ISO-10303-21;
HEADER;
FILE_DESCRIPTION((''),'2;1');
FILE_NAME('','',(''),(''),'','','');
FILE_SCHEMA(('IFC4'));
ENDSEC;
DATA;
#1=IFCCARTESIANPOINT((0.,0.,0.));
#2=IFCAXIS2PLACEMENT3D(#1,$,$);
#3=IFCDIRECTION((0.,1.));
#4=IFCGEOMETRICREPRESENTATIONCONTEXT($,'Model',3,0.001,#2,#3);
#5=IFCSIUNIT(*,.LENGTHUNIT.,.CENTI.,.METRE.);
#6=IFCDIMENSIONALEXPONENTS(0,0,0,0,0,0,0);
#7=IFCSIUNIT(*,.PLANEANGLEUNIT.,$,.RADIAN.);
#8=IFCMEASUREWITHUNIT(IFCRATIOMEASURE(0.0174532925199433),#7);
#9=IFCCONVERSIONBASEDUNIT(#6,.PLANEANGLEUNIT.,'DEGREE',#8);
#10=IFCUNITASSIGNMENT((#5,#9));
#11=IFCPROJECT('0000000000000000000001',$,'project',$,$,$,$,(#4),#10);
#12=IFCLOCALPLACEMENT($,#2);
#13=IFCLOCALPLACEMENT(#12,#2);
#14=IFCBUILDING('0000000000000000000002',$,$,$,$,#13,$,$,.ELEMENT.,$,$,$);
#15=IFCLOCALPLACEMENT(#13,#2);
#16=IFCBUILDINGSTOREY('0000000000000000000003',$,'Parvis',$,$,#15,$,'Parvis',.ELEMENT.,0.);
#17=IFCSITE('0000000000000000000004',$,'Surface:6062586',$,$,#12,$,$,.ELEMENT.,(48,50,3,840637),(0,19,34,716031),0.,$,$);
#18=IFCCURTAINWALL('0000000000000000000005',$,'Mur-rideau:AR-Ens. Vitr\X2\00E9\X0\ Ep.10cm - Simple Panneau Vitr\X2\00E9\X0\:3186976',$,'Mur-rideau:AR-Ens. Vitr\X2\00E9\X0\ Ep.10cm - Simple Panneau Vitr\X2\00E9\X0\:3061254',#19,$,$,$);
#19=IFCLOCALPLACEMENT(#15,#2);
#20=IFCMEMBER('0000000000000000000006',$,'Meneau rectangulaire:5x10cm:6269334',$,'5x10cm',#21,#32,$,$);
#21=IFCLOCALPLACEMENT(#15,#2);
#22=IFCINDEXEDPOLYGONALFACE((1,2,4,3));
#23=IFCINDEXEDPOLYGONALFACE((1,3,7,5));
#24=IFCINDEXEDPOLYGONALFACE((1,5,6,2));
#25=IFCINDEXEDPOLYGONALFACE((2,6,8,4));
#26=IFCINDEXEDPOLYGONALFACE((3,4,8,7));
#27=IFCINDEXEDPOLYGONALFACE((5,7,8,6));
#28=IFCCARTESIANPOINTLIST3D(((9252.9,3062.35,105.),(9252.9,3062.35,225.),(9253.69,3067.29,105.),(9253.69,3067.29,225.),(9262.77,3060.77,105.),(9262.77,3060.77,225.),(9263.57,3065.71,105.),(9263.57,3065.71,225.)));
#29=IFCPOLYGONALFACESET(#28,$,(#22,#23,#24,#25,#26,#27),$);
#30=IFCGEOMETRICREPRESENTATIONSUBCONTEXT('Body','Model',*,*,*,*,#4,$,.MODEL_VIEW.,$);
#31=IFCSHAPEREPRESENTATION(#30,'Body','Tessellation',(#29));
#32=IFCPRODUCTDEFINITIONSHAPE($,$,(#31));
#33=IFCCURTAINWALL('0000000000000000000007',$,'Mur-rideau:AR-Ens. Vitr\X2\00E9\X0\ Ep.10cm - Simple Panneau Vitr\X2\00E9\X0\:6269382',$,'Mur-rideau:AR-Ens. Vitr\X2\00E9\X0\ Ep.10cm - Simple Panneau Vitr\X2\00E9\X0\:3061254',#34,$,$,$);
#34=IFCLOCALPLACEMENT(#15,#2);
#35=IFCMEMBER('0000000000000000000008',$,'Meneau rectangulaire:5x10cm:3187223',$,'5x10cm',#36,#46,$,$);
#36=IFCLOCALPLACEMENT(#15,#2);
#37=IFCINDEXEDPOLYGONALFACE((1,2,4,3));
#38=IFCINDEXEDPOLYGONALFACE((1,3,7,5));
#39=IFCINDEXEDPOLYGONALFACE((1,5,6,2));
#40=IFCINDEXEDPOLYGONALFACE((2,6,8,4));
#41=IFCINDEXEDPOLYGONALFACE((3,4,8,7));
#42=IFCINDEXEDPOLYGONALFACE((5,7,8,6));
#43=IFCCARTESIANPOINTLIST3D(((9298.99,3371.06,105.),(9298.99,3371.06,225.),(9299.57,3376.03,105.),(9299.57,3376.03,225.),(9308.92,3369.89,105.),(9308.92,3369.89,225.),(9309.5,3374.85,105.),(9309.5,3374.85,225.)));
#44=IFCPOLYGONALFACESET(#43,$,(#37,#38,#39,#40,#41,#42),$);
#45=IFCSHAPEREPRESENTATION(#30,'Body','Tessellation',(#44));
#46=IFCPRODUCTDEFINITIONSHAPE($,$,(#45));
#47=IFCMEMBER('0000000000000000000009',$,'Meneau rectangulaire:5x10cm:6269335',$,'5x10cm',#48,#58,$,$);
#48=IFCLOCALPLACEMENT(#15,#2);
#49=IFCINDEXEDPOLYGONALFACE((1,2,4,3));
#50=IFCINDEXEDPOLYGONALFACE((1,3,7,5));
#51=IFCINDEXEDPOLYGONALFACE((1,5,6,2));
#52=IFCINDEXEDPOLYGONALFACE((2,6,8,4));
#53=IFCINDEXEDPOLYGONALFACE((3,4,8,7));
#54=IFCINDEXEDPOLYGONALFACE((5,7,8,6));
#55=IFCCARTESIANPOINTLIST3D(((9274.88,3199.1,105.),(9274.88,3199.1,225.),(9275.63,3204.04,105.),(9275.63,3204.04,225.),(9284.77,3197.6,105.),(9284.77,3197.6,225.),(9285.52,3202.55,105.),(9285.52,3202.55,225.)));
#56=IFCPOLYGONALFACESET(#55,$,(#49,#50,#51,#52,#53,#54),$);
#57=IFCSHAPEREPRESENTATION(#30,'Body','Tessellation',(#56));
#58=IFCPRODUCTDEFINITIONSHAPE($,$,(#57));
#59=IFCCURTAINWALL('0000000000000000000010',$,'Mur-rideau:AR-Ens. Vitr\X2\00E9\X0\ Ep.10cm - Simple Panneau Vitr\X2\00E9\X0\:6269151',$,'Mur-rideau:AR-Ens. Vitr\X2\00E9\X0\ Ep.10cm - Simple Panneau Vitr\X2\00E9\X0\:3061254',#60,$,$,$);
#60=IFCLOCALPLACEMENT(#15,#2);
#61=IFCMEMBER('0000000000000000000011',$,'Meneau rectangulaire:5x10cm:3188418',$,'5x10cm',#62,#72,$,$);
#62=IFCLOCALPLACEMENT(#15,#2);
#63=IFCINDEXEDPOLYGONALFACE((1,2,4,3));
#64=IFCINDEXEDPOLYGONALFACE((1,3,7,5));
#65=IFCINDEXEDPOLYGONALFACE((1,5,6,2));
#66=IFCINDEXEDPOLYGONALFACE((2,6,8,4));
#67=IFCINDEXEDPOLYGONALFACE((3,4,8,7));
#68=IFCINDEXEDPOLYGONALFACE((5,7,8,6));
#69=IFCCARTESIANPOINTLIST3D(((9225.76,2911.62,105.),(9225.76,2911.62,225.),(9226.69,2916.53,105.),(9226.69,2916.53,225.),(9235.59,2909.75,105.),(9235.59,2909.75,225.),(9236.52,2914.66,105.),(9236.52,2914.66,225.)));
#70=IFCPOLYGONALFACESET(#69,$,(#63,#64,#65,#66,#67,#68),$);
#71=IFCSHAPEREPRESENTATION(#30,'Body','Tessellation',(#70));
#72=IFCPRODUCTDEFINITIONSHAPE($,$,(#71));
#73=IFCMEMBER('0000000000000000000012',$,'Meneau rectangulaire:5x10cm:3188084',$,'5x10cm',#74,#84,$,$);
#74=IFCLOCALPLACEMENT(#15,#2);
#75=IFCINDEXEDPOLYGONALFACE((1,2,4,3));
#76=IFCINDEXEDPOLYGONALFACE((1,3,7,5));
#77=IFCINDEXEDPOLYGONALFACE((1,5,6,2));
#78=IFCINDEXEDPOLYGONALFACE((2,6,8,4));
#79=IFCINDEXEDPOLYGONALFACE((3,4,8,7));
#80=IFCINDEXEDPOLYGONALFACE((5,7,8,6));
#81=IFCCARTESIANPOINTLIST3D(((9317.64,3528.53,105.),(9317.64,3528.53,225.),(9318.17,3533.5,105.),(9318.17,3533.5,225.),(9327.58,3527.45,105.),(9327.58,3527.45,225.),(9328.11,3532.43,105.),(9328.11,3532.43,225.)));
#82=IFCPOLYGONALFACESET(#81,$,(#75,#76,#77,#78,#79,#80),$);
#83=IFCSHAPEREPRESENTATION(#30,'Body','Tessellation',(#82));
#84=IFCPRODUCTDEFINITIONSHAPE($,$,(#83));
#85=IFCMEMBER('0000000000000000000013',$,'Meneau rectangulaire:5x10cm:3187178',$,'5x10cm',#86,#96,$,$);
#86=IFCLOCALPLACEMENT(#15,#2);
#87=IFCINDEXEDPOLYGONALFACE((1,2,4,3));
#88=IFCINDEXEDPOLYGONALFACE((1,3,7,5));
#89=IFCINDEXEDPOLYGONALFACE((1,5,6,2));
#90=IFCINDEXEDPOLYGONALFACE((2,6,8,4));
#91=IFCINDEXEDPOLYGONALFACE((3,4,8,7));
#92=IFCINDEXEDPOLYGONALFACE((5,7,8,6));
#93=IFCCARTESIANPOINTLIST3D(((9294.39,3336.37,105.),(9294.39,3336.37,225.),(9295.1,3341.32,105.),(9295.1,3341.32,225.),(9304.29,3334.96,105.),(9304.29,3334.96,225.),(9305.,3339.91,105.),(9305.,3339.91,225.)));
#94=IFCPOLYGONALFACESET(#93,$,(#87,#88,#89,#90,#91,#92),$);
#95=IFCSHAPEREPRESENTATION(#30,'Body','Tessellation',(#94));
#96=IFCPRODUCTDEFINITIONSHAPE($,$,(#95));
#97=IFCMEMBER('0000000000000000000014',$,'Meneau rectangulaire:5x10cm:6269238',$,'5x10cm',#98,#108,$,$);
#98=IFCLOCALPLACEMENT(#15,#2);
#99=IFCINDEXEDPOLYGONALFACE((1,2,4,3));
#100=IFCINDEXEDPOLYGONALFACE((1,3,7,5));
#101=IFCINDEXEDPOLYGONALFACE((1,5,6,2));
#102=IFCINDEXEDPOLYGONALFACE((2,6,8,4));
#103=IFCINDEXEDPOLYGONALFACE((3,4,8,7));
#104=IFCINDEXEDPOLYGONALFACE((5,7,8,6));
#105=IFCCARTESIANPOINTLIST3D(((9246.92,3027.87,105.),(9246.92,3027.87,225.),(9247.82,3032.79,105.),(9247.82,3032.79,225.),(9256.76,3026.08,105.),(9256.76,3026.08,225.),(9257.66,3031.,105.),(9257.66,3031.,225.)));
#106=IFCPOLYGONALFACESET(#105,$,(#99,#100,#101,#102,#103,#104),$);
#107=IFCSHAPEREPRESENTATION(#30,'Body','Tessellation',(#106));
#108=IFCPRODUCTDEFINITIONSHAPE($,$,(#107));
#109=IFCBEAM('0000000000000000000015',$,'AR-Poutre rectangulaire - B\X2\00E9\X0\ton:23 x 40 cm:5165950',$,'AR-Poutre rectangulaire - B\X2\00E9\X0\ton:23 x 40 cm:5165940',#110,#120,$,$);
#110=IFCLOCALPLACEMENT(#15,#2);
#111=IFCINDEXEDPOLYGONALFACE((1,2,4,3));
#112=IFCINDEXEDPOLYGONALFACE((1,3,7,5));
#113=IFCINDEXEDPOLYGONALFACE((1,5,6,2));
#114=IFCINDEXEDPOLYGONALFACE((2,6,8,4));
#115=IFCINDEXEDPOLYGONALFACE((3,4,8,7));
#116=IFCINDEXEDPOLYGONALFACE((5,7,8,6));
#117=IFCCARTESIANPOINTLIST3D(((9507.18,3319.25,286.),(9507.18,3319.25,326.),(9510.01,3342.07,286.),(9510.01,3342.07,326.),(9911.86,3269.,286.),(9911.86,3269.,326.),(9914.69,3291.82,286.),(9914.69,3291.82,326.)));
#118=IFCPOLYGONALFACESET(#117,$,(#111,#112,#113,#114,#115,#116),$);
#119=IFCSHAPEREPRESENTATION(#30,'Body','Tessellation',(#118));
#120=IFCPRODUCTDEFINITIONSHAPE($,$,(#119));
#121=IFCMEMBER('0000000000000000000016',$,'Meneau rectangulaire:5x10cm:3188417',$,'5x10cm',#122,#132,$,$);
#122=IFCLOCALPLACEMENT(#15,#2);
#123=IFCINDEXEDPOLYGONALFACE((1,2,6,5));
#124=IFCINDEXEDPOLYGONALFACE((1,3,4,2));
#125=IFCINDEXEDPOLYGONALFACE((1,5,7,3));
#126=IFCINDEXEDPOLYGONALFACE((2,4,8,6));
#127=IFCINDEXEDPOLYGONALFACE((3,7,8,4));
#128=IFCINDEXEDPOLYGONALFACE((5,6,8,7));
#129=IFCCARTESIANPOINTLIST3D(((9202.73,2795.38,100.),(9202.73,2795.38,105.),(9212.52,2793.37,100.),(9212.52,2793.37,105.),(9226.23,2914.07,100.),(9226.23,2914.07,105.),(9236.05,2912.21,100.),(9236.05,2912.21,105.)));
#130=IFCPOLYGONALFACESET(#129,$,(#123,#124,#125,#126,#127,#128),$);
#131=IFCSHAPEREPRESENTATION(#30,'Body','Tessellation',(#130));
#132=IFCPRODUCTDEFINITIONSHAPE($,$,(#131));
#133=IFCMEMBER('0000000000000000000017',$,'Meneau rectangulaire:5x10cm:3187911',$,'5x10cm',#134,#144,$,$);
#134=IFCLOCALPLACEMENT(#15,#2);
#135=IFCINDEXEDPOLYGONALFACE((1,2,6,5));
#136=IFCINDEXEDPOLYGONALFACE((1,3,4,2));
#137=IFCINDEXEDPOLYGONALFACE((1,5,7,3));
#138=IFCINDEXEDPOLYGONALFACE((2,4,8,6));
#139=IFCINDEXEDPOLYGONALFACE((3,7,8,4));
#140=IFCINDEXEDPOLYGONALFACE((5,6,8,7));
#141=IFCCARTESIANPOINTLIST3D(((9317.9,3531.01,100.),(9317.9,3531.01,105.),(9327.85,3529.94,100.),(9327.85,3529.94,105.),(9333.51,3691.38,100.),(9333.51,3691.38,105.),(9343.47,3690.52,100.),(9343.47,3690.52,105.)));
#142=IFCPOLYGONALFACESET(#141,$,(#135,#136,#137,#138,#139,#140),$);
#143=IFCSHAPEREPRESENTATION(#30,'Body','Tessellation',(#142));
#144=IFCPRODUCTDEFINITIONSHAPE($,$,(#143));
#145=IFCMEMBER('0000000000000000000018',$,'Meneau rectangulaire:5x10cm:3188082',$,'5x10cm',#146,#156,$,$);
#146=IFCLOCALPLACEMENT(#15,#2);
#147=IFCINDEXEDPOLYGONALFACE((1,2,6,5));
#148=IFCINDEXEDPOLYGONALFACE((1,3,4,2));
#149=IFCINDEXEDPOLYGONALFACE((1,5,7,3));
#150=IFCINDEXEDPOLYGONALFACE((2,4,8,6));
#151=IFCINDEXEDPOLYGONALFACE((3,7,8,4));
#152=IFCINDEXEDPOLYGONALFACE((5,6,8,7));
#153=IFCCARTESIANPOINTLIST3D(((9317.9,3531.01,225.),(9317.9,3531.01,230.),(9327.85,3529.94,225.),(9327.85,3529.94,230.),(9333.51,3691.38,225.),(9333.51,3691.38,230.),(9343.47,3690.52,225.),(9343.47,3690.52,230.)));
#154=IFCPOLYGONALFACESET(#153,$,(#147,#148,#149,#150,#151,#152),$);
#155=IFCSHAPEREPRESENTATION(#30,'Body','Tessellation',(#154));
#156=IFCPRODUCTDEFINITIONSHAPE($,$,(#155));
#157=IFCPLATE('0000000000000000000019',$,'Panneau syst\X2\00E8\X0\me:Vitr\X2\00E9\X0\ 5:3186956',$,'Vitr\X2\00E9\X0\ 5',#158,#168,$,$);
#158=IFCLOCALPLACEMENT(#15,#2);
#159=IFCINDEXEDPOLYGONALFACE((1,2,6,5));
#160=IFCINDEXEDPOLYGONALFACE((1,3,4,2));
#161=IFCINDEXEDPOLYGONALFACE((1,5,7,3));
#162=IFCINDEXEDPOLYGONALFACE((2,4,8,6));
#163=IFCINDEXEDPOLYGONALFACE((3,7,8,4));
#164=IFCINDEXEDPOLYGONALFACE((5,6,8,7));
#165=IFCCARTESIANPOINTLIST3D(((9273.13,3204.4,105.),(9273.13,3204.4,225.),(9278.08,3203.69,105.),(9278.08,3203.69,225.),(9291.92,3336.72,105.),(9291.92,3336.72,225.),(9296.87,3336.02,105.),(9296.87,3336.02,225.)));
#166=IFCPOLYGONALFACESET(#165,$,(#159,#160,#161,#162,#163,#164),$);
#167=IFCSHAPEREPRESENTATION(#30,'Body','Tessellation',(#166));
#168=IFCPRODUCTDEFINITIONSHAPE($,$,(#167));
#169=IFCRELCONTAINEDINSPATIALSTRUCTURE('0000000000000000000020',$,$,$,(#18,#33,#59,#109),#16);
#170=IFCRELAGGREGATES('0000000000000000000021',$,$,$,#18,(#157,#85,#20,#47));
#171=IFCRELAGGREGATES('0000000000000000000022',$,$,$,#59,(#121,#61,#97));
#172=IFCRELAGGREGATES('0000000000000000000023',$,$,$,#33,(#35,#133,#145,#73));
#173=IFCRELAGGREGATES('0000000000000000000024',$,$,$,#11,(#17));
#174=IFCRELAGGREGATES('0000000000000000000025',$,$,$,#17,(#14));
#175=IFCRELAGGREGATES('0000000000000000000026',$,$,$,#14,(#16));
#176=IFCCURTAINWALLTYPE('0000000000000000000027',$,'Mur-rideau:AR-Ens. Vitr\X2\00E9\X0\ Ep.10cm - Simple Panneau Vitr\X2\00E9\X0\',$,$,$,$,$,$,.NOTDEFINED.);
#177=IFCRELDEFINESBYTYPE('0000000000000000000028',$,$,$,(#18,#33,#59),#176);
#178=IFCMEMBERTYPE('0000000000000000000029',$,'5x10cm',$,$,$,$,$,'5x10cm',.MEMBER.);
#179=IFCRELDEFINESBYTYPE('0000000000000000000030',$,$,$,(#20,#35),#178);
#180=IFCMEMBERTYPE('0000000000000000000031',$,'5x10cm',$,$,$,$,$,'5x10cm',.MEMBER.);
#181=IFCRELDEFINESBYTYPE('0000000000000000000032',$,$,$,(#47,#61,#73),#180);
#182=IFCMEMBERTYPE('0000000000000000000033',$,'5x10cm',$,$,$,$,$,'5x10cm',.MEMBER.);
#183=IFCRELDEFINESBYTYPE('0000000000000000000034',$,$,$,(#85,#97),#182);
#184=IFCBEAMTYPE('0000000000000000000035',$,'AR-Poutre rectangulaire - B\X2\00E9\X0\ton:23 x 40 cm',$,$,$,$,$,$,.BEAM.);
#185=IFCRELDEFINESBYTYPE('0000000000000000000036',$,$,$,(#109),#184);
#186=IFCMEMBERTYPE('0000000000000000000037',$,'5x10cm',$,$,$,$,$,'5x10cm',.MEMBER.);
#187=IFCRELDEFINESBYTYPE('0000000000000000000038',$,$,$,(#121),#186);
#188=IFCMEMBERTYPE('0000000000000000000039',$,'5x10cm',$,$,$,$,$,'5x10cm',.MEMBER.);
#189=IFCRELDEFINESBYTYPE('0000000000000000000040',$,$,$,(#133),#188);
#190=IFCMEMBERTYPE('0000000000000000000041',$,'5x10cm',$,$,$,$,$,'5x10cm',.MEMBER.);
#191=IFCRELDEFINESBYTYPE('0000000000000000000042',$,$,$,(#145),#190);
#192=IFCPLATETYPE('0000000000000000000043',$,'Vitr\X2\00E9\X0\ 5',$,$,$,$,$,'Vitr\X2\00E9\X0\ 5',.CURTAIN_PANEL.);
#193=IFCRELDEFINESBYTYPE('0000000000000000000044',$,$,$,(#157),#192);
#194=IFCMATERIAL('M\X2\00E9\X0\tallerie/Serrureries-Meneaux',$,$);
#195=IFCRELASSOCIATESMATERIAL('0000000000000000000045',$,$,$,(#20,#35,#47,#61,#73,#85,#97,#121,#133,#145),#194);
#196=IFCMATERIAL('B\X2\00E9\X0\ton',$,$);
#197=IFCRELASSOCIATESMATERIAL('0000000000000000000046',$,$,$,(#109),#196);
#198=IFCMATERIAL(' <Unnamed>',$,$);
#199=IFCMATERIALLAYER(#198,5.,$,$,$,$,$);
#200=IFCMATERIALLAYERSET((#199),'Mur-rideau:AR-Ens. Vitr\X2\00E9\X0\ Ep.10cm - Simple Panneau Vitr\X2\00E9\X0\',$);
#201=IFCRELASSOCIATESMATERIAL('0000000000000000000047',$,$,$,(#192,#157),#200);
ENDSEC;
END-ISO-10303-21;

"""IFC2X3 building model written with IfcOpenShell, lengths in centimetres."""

from ifc_helpers import new_model, entity, si_unit, converted_unit, direction, frame, frame_2d, origin, origin_2d_with_axis, place, context, subcontext, project, spatial, rectangle, extrude, clip, halfspace, source, transform, mapped, material, layer, layer_set, layer_usage, type_object, type_shapes, element, aggregate, save


model = new_model("IFC2X3")

# Units and contexts
model_context = context("Model", 3, precision=0.001, world=origin(), true_north=direction((0.0, 1.0)))
body_context = subcontext(model_context, "Body", "Model", "MODEL_VIEW")
ifc_project = project(units=[si_unit("LENGTHUNIT", "METRE", prefix="CENTI"), converted_unit("PLANEANGLEUNIT", "DEGREE", entity("IfcRatioMeasure", 0.0174532925199433), si_unit("PLANEANGLEUNIT", "RADIAN"), dimensions=[0, 0, 0, 0, 0, 0, 0])], contexts=[model_context])

# Site, building, storey
site_placement = place(None, origin())
site = spatial("IfcSite", under=ifc_project, at=site_placement, Name="Surface:6062586", CompositionType="ELEMENT", RefLatitude=(48, 50, 3, 840637), RefLongitude=(0, 19, 34, 716031), RefElevation=0.0)
building_placement = place(site_placement, origin())
building = spatial("IfcBuilding", under=site, at=building_placement, CompositionType="ELEMENT")
storey_placement = place(building_placement, frame((0.0, 0.0, 0.0)))
storey = spatial("IfcBuildingStorey", under=building, at=storey_placement, Name="Parvis", LongName="Parvis", CompositionType="ELEMENT", Elevation=0.0)

# Shared definitions
ifc_material_1 = material(Name="Béton")

# Curtain walls, members
curtain_wall_type = type_object("IfcCurtainWallType", Name="Mur-rideau:AR-Ens. Vitré Ep.10cm - Simple Panneau Vitré", PredefinedType="NOTDEFINED")
curtain_wall_1_placement = place(storey_placement, frame((0.0, 0.0, 0.0)))
curtain_wall_1 = element("IfcCurtainWall", 1, at=curtain_wall_1_placement, inside=storey, type_object=curtain_wall_type, Name="Mur-rideau:AR-Ens. Vitré Ep.10cm - Simple Panneau Vitré:3186976", ObjectType="Mur-rideau:AR-Ens. Vitré Ep.10cm - Simple Panneau Vitré:3061254")
ifc_material_2 = material(Name="Métallerie/Serrureries-Meneaux")
member_type_1 = type_object("IfcMemberType", Name="5x10cm", ElementType="5x10cm", PredefinedType="MEMBER")
shared_shape_1 = source(origin(), body_context, "Body", "SweptSolid", [
    extrude(rectangle(XDim=10.0, YDim=5.0, at=origin_2d_with_axis()), frame((-2.5, -5.0, -120.0), z_axis=(0.0, 0.0, 1.0), x_axis=(0.0, -1.0, 0.0)), (0.0, 0.0, 1.0), 120.0),
])
type_shapes(member_type_1, [shared_shape_1])
member_1_placement = place(storey_placement, frame((9252.9, 3062.35, 105.0), z_axis=(0.0, 0.0, -1.0), x_axis=(-0.158533, -0.987354, 0.0)))
member_1 = element("IfcMember", 2, at=member_1_placement, type_object=member_type_1, material=ifc_material_2, Name="Meneau rectangulaire:5x10cm:6269334", ObjectType="5x10cm", context=body_context, shape_type="MappedRepresentation", body=[
    mapped(shared_shape_1, transform((0.0, 0.0, 0.0), scale=1.0)),
])
curtain_wall_2_placement = place(storey_placement, frame((0.0, 0.0, 0.0)))
curtain_wall_2 = element("IfcCurtainWall", 3, at=curtain_wall_2_placement, inside=storey, type_object=curtain_wall_type, Name="Mur-rideau:AR-Ens. Vitré Ep.10cm - Simple Panneau Vitré:6269382", ObjectType="Mur-rideau:AR-Ens. Vitré Ep.10cm - Simple Panneau Vitré:3061254")
member_2_placement = place(storey_placement, frame((9298.99, 3371.06, 105.0), z_axis=(0.0, 0.0, -1.0), x_axis=(-0.117457, -0.993078, 0.0)))
member_2 = element("IfcMember", 4, at=member_2_placement, type_object=member_type_1, material=ifc_material_2, Name="Meneau rectangulaire:5x10cm:3187223", ObjectType="5x10cm", context=body_context, shape_type="MappedRepresentation", body=[
    mapped(shared_shape_1, transform((0.0, 0.0, 0.0), scale=1.0)),
])

# Member
member_type_2 = type_object("IfcMemberType", Name="5x10cm", ElementType="5x10cm", PredefinedType="MEMBER")
shared_shape_2 = source(origin(), body_context, "Body", "SweptSolid", [
    extrude(rectangle(XDim=10.0, YDim=5.0, at=origin_2d_with_axis()), frame((0.0, -5.0, -120.0), z_axis=(0.0, 0.0, 1.0), x_axis=(0.0, -1.0, 0.0)), (0.0, 0.0, 1.0), 120.0),
])
type_shapes(member_type_2, [shared_shape_2])
member_3_placement = place(storey_placement, frame((9275.25, 3201.57, 105.0), z_axis=(0.0, 0.0, -1.0), x_axis=(-0.149566, -0.988752, 0.0)))
member_3 = element("IfcMember", 5, at=member_3_placement, type_object=member_type_2, material=ifc_material_2, Name="Meneau rectangulaire:5x10cm:6269335", ObjectType="5x10cm", context=body_context, shape_type="MappedRepresentation", body=[
    mapped(shared_shape_2, transform((0.0, 0.0, 0.0), scale=1.0)),
])

# Curtain wall, member
curtain_wall_3_placement = place(storey_placement, frame((0.0, 0.0, 0.0)))
curtain_wall_3 = element("IfcCurtainWall", 6, at=curtain_wall_3_placement, inside=storey, type_object=curtain_wall_type, Name="Mur-rideau:AR-Ens. Vitré Ep.10cm - Simple Panneau Vitré:6269151", ObjectType="Mur-rideau:AR-Ens. Vitré Ep.10cm - Simple Panneau Vitré:3061254")
member_4_placement = place(storey_placement, frame((9226.23, 2914.07, 105.0), z_axis=(0.0, 0.0, -1.0), x_axis=(-0.186576, -0.982441, 0.0)))
member_4 = element("IfcMember", 7, at=member_4_placement, type_object=member_type_2, material=ifc_material_2, Name="Meneau rectangulaire:5x10cm:3188418", ObjectType="5x10cm", context=body_context, shape_type="MappedRepresentation", body=[
    mapped(shared_shape_2, transform((0.0, 0.0, 0.0), scale=1.0)),
])

# Members
member_5_placement = place(storey_placement, frame((9317.9, 3531.01, 105.0), z_axis=(0.0, 0.0, -1.0), x_axis=(-0.107155, -0.994242, 0.0)))
member_5 = element("IfcMember", 8, at=member_5_placement, type_object=member_type_2, material=ifc_material_2, Name="Meneau rectangulaire:5x10cm:3188084", ObjectType="5x10cm", context=body_context, shape_type="MappedRepresentation", body=[
    mapped(shared_shape_2, transform((0.0, 0.0, 0.0), scale=1.0)),
])
member_type_3 = type_object("IfcMemberType", Name="5x10cm", ElementType="5x10cm", PredefinedType="MEMBER")
shared_shape_3 = source(origin(), body_context, "Body", "SweptSolid", [
    extrude(rectangle(XDim=10.0, YDim=5.0, at=origin_2d_with_axis()), frame((-2.5, -5.0, -120.0), z_axis=(0.0, 0.0, 1.0), x_axis=(0.0, -1.0, 0.0)), (0.0, 0.0, 1.0), 120.0),
])
type_shapes(member_type_3, [shared_shape_3])
member_6_placement = place(storey_placement, frame((9295.1, 3341.32, 225.0), z_axis=(0.0, 0.0, 1.0), x_axis=(0.140576, 0.99007, 0.0)))
member_6 = element("IfcMember", 9, at=member_6_placement, type_object=member_type_3, material=ifc_material_2, Name="Meneau rectangulaire:5x10cm:3187178", ObjectType="5x10cm", context=body_context, shape_type="MappedRepresentation", body=[
    mapped(shared_shape_3, transform((0.0, 0.0, 0.0), scale=1.0)),
])
member_7_placement = place(storey_placement, frame((9247.82, 3032.79, 225.0), z_axis=(0.0, 0.0, 1.0), x_axis=(0.17894, 0.98386, 0.0)))
member_7 = element("IfcMember", 10, at=member_7_placement, type_object=member_type_3, material=ifc_material_2, Name="Meneau rectangulaire:5x10cm:6269238", ObjectType="5x10cm", context=body_context, shape_type="MappedRepresentation", body=[
    mapped(shared_shape_3, transform((0.0, 0.0, 0.0), scale=1.0)),
])

# Beam
beam_type_1 = type_object("IfcBeamType", Name="AR-Poutre rectangulaire - Béton:23 x 40 cm", PredefinedType="BEAM")
beam_1_placement = place(storey_placement, frame((9508.59, 3330.66, 326.0), z_axis=(0.0, 0.0, 1.0), x_axis=(0.992379, -0.123227, 0.0)))
element("IfcBeam", 11, at=beam_1_placement, inside=storey, type_object=beam_type_1, material=ifc_material_1, Name="AR-Poutre rectangulaire - Béton:23 x 40 cm:5165950", ObjectType="AR-Poutre rectangulaire - Béton:23 x 40 cm:5165940", context=body_context, shape_type="SweptSolid", body=[
    extrude(rectangle(XDim=40.0, YDim=23.0, at=frame_2d((0.0, 0.0), x_axis=(1.0, 0.0))), frame((0.0, 0.0, -20.0), z_axis=(1.0, 0.0, 0.0), x_axis=(0.0, 0.0, -1.0)), (0.0, 0.0, 1.0), 407.79),
])

# Members
member_type_4 = type_object("IfcMemberType", Name="5x10cm", ElementType="5x10cm", PredefinedType="MEMBER")
shared_shape_4 = source(origin(), body_context, "Body", "Clipping", [
    clip(clip(extrude(rectangle(XDim=10.0, YDim=5.0, at=origin_2d_with_axis()), frame((-2.5, -5.0, -121.07), z_axis=(0.0, 0.0, 1.0), x_axis=(0.0, -1.0, 0.0)), (0.0, 0.0, 1.0), 121.15), halfspace(frame((-30.48, 0.0, -120.99), z_axis=(0.0, 0.007777, -0.99997), x_axis=(1.0, 0.0, 0.0)), False)), halfspace(frame((-30.48, 0.0, 0.0), z_axis=(0.0, 0.007777, 0.99997), x_axis=(1.0, 0.0, 0.0)), False)),
])
type_shapes(member_type_4, [shared_shape_4])
member_8_placement = place(storey_placement, frame((9226.23, 2914.07, 100.0), z_axis=(0.194221, 0.980958, 0.0), x_axis=(0.0, 0.0, -1.0)))
member_8 = element("IfcMember", 12, at=member_8_placement, type_object=member_type_4, material=ifc_material_2, Name="Meneau rectangulaire:5x10cm:3188417", ObjectType="5x10cm", context=body_context, shape_type="MappedRepresentation", body=[
    mapped(shared_shape_4, transform((0.0, 0.0, 0.0), scale=1.0)),
])
member_type_5 = type_object("IfcMemberType", Name="5x10cm", ElementType="5x10cm", PredefinedType="MEMBER")
shared_shape_5 = source(origin(), body_context, "Body", "Clipping", [
    clip(clip(extrude(rectangle(XDim=10.0, YDim=5.0, at=origin_2d_with_axis()), frame((-2.5, -5.0, -161.23), z_axis=(0.0, 0.0, 1.0), x_axis=(0.0, -1.0, 0.0)), (0.0, 0.0, 1.0), 161.34), halfspace(frame((-30.48, 0.0, -161.13), z_axis=(0.0, 0.010369, -0.999946), x_axis=(1.0, 0.0, 0.0)), False)), halfspace(frame((-30.48, 0.0, 0.0), z_axis=(0.0, 0.010369, 0.999946), x_axis=(1.0, 0.0, 0.0)), False)),
])
type_shapes(member_type_5, [shared_shape_5])
member_9_placement = place(storey_placement, frame((9333.51, 3691.38, 100.0), z_axis=(0.096838, 0.9953, 0.0), x_axis=(0.0, 0.0, -1.0)))
member_9 = element("IfcMember", 13, at=member_9_placement, type_object=member_type_5, material=ifc_material_2, Name="Meneau rectangulaire:5x10cm:3187911", ObjectType="5x10cm", context=body_context, shape_type="MappedRepresentation", body=[
    mapped(shared_shape_5, transform((0.0, 0.0, 0.0), scale=1.0)),
])
member_type_6 = type_object("IfcMemberType", Name="5x10cm", ElementType="5x10cm", PredefinedType="MEMBER")
shared_shape_6 = source(origin(), body_context, "Body", "Clipping", [
    clip(clip(extrude(rectangle(XDim=10.0, YDim=5.0, at=origin_2d_with_axis()), frame((-2.5, -5.0, -161.23), z_axis=(0.0, 0.0, 1.0), x_axis=(0.0, -1.0, 0.0)), (0.0, 0.0, 1.0), 161.34), halfspace(frame((-30.48, 0.0, -161.13), z_axis=(0.0, 0.010369, -0.999946), x_axis=(1.0, 0.0, 0.0)), False)), halfspace(frame((-30.48, 0.0, 0.0), z_axis=(0.0, 0.010369, 0.999946), x_axis=(1.0, 0.0, 0.0)), False)),
])
type_shapes(member_type_6, [shared_shape_6])
member_10_placement = place(storey_placement, frame((9317.9, 3531.01, 230.0), z_axis=(-0.096838, -0.9953, 0.0), x_axis=(0.0, 0.0, 1.0)))
member_10 = element("IfcMember", 14, at=member_10_placement, type_object=member_type_6, material=ifc_material_2, Name="Meneau rectangulaire:5x10cm:3188082", ObjectType="5x10cm", context=body_context, shape_type="MappedRepresentation", body=[
    mapped(shared_shape_6, transform((0.0, 0.0, 0.0), scale=1.0)),
])

# Plate
ifc_material_3 = material(Name=" <Unnamed>")
ifc_layer_1 = layer(ifc_material_3, 5.0)
ifc_layer_set_1 = layer_set([ifc_layer_1], Name="Mur-rideau:AR-Ens. Vitré Ep.10cm - Simple Panneau Vitré")
ifc_layer_usage_1 = layer_usage(ifc_layer_set_1, "AXIS3", "POSITIVE", 0.0)
plate_type_1 = type_object("IfcPlateType", Name="Vitré 5", ElementType="Vitré 5", PredefinedType="CURTAIN_PANEL", material=ifc_layer_set_1)
shared_shape_7 = source(origin(), body_context, "Body", "SweptSolid", [
    extrude(rectangle(XDim=5.0, YDim=133.65, at=frame_2d((0.0, 0.0), x_axis=(1.0, 0.0))), frame((0.0, 0.0, 0.0), z_axis=(0.0, 0.0, 1.0), x_axis=(0.0, 1.0, 0.0)), (0.0, 0.0, 1.0), 120.0),
])
type_shapes(plate_type_1, [shared_shape_7])
plate_1_placement = place(curtain_wall_1_placement, frame((9285.0, 3270.21, 105.0), z_axis=(0.0, 0.0, 1.0), x_axis=(-0.140576, -0.99007, 0.0)))
plate_1 = element("IfcPlate", 15, at=plate_1_placement, type_object=plate_type_1, material=ifc_layer_usage_1, Name="Panneau système:Vitré 5:3186956", ObjectType="Vitré 5", context=body_context, shape_type="MappedRepresentation", body=[
    mapped(shared_shape_7, transform((0.0, 0.0, 0.0), scale=1.0)),
])
aggregate(curtain_wall_1, [plate_1, member_6, member_1, member_3])
aggregate(curtain_wall_3, [member_8, member_4, member_7])
aggregate(curtain_wall_2, [member_2, member_9, member_10, member_5])

save(model, "model.ifc")
